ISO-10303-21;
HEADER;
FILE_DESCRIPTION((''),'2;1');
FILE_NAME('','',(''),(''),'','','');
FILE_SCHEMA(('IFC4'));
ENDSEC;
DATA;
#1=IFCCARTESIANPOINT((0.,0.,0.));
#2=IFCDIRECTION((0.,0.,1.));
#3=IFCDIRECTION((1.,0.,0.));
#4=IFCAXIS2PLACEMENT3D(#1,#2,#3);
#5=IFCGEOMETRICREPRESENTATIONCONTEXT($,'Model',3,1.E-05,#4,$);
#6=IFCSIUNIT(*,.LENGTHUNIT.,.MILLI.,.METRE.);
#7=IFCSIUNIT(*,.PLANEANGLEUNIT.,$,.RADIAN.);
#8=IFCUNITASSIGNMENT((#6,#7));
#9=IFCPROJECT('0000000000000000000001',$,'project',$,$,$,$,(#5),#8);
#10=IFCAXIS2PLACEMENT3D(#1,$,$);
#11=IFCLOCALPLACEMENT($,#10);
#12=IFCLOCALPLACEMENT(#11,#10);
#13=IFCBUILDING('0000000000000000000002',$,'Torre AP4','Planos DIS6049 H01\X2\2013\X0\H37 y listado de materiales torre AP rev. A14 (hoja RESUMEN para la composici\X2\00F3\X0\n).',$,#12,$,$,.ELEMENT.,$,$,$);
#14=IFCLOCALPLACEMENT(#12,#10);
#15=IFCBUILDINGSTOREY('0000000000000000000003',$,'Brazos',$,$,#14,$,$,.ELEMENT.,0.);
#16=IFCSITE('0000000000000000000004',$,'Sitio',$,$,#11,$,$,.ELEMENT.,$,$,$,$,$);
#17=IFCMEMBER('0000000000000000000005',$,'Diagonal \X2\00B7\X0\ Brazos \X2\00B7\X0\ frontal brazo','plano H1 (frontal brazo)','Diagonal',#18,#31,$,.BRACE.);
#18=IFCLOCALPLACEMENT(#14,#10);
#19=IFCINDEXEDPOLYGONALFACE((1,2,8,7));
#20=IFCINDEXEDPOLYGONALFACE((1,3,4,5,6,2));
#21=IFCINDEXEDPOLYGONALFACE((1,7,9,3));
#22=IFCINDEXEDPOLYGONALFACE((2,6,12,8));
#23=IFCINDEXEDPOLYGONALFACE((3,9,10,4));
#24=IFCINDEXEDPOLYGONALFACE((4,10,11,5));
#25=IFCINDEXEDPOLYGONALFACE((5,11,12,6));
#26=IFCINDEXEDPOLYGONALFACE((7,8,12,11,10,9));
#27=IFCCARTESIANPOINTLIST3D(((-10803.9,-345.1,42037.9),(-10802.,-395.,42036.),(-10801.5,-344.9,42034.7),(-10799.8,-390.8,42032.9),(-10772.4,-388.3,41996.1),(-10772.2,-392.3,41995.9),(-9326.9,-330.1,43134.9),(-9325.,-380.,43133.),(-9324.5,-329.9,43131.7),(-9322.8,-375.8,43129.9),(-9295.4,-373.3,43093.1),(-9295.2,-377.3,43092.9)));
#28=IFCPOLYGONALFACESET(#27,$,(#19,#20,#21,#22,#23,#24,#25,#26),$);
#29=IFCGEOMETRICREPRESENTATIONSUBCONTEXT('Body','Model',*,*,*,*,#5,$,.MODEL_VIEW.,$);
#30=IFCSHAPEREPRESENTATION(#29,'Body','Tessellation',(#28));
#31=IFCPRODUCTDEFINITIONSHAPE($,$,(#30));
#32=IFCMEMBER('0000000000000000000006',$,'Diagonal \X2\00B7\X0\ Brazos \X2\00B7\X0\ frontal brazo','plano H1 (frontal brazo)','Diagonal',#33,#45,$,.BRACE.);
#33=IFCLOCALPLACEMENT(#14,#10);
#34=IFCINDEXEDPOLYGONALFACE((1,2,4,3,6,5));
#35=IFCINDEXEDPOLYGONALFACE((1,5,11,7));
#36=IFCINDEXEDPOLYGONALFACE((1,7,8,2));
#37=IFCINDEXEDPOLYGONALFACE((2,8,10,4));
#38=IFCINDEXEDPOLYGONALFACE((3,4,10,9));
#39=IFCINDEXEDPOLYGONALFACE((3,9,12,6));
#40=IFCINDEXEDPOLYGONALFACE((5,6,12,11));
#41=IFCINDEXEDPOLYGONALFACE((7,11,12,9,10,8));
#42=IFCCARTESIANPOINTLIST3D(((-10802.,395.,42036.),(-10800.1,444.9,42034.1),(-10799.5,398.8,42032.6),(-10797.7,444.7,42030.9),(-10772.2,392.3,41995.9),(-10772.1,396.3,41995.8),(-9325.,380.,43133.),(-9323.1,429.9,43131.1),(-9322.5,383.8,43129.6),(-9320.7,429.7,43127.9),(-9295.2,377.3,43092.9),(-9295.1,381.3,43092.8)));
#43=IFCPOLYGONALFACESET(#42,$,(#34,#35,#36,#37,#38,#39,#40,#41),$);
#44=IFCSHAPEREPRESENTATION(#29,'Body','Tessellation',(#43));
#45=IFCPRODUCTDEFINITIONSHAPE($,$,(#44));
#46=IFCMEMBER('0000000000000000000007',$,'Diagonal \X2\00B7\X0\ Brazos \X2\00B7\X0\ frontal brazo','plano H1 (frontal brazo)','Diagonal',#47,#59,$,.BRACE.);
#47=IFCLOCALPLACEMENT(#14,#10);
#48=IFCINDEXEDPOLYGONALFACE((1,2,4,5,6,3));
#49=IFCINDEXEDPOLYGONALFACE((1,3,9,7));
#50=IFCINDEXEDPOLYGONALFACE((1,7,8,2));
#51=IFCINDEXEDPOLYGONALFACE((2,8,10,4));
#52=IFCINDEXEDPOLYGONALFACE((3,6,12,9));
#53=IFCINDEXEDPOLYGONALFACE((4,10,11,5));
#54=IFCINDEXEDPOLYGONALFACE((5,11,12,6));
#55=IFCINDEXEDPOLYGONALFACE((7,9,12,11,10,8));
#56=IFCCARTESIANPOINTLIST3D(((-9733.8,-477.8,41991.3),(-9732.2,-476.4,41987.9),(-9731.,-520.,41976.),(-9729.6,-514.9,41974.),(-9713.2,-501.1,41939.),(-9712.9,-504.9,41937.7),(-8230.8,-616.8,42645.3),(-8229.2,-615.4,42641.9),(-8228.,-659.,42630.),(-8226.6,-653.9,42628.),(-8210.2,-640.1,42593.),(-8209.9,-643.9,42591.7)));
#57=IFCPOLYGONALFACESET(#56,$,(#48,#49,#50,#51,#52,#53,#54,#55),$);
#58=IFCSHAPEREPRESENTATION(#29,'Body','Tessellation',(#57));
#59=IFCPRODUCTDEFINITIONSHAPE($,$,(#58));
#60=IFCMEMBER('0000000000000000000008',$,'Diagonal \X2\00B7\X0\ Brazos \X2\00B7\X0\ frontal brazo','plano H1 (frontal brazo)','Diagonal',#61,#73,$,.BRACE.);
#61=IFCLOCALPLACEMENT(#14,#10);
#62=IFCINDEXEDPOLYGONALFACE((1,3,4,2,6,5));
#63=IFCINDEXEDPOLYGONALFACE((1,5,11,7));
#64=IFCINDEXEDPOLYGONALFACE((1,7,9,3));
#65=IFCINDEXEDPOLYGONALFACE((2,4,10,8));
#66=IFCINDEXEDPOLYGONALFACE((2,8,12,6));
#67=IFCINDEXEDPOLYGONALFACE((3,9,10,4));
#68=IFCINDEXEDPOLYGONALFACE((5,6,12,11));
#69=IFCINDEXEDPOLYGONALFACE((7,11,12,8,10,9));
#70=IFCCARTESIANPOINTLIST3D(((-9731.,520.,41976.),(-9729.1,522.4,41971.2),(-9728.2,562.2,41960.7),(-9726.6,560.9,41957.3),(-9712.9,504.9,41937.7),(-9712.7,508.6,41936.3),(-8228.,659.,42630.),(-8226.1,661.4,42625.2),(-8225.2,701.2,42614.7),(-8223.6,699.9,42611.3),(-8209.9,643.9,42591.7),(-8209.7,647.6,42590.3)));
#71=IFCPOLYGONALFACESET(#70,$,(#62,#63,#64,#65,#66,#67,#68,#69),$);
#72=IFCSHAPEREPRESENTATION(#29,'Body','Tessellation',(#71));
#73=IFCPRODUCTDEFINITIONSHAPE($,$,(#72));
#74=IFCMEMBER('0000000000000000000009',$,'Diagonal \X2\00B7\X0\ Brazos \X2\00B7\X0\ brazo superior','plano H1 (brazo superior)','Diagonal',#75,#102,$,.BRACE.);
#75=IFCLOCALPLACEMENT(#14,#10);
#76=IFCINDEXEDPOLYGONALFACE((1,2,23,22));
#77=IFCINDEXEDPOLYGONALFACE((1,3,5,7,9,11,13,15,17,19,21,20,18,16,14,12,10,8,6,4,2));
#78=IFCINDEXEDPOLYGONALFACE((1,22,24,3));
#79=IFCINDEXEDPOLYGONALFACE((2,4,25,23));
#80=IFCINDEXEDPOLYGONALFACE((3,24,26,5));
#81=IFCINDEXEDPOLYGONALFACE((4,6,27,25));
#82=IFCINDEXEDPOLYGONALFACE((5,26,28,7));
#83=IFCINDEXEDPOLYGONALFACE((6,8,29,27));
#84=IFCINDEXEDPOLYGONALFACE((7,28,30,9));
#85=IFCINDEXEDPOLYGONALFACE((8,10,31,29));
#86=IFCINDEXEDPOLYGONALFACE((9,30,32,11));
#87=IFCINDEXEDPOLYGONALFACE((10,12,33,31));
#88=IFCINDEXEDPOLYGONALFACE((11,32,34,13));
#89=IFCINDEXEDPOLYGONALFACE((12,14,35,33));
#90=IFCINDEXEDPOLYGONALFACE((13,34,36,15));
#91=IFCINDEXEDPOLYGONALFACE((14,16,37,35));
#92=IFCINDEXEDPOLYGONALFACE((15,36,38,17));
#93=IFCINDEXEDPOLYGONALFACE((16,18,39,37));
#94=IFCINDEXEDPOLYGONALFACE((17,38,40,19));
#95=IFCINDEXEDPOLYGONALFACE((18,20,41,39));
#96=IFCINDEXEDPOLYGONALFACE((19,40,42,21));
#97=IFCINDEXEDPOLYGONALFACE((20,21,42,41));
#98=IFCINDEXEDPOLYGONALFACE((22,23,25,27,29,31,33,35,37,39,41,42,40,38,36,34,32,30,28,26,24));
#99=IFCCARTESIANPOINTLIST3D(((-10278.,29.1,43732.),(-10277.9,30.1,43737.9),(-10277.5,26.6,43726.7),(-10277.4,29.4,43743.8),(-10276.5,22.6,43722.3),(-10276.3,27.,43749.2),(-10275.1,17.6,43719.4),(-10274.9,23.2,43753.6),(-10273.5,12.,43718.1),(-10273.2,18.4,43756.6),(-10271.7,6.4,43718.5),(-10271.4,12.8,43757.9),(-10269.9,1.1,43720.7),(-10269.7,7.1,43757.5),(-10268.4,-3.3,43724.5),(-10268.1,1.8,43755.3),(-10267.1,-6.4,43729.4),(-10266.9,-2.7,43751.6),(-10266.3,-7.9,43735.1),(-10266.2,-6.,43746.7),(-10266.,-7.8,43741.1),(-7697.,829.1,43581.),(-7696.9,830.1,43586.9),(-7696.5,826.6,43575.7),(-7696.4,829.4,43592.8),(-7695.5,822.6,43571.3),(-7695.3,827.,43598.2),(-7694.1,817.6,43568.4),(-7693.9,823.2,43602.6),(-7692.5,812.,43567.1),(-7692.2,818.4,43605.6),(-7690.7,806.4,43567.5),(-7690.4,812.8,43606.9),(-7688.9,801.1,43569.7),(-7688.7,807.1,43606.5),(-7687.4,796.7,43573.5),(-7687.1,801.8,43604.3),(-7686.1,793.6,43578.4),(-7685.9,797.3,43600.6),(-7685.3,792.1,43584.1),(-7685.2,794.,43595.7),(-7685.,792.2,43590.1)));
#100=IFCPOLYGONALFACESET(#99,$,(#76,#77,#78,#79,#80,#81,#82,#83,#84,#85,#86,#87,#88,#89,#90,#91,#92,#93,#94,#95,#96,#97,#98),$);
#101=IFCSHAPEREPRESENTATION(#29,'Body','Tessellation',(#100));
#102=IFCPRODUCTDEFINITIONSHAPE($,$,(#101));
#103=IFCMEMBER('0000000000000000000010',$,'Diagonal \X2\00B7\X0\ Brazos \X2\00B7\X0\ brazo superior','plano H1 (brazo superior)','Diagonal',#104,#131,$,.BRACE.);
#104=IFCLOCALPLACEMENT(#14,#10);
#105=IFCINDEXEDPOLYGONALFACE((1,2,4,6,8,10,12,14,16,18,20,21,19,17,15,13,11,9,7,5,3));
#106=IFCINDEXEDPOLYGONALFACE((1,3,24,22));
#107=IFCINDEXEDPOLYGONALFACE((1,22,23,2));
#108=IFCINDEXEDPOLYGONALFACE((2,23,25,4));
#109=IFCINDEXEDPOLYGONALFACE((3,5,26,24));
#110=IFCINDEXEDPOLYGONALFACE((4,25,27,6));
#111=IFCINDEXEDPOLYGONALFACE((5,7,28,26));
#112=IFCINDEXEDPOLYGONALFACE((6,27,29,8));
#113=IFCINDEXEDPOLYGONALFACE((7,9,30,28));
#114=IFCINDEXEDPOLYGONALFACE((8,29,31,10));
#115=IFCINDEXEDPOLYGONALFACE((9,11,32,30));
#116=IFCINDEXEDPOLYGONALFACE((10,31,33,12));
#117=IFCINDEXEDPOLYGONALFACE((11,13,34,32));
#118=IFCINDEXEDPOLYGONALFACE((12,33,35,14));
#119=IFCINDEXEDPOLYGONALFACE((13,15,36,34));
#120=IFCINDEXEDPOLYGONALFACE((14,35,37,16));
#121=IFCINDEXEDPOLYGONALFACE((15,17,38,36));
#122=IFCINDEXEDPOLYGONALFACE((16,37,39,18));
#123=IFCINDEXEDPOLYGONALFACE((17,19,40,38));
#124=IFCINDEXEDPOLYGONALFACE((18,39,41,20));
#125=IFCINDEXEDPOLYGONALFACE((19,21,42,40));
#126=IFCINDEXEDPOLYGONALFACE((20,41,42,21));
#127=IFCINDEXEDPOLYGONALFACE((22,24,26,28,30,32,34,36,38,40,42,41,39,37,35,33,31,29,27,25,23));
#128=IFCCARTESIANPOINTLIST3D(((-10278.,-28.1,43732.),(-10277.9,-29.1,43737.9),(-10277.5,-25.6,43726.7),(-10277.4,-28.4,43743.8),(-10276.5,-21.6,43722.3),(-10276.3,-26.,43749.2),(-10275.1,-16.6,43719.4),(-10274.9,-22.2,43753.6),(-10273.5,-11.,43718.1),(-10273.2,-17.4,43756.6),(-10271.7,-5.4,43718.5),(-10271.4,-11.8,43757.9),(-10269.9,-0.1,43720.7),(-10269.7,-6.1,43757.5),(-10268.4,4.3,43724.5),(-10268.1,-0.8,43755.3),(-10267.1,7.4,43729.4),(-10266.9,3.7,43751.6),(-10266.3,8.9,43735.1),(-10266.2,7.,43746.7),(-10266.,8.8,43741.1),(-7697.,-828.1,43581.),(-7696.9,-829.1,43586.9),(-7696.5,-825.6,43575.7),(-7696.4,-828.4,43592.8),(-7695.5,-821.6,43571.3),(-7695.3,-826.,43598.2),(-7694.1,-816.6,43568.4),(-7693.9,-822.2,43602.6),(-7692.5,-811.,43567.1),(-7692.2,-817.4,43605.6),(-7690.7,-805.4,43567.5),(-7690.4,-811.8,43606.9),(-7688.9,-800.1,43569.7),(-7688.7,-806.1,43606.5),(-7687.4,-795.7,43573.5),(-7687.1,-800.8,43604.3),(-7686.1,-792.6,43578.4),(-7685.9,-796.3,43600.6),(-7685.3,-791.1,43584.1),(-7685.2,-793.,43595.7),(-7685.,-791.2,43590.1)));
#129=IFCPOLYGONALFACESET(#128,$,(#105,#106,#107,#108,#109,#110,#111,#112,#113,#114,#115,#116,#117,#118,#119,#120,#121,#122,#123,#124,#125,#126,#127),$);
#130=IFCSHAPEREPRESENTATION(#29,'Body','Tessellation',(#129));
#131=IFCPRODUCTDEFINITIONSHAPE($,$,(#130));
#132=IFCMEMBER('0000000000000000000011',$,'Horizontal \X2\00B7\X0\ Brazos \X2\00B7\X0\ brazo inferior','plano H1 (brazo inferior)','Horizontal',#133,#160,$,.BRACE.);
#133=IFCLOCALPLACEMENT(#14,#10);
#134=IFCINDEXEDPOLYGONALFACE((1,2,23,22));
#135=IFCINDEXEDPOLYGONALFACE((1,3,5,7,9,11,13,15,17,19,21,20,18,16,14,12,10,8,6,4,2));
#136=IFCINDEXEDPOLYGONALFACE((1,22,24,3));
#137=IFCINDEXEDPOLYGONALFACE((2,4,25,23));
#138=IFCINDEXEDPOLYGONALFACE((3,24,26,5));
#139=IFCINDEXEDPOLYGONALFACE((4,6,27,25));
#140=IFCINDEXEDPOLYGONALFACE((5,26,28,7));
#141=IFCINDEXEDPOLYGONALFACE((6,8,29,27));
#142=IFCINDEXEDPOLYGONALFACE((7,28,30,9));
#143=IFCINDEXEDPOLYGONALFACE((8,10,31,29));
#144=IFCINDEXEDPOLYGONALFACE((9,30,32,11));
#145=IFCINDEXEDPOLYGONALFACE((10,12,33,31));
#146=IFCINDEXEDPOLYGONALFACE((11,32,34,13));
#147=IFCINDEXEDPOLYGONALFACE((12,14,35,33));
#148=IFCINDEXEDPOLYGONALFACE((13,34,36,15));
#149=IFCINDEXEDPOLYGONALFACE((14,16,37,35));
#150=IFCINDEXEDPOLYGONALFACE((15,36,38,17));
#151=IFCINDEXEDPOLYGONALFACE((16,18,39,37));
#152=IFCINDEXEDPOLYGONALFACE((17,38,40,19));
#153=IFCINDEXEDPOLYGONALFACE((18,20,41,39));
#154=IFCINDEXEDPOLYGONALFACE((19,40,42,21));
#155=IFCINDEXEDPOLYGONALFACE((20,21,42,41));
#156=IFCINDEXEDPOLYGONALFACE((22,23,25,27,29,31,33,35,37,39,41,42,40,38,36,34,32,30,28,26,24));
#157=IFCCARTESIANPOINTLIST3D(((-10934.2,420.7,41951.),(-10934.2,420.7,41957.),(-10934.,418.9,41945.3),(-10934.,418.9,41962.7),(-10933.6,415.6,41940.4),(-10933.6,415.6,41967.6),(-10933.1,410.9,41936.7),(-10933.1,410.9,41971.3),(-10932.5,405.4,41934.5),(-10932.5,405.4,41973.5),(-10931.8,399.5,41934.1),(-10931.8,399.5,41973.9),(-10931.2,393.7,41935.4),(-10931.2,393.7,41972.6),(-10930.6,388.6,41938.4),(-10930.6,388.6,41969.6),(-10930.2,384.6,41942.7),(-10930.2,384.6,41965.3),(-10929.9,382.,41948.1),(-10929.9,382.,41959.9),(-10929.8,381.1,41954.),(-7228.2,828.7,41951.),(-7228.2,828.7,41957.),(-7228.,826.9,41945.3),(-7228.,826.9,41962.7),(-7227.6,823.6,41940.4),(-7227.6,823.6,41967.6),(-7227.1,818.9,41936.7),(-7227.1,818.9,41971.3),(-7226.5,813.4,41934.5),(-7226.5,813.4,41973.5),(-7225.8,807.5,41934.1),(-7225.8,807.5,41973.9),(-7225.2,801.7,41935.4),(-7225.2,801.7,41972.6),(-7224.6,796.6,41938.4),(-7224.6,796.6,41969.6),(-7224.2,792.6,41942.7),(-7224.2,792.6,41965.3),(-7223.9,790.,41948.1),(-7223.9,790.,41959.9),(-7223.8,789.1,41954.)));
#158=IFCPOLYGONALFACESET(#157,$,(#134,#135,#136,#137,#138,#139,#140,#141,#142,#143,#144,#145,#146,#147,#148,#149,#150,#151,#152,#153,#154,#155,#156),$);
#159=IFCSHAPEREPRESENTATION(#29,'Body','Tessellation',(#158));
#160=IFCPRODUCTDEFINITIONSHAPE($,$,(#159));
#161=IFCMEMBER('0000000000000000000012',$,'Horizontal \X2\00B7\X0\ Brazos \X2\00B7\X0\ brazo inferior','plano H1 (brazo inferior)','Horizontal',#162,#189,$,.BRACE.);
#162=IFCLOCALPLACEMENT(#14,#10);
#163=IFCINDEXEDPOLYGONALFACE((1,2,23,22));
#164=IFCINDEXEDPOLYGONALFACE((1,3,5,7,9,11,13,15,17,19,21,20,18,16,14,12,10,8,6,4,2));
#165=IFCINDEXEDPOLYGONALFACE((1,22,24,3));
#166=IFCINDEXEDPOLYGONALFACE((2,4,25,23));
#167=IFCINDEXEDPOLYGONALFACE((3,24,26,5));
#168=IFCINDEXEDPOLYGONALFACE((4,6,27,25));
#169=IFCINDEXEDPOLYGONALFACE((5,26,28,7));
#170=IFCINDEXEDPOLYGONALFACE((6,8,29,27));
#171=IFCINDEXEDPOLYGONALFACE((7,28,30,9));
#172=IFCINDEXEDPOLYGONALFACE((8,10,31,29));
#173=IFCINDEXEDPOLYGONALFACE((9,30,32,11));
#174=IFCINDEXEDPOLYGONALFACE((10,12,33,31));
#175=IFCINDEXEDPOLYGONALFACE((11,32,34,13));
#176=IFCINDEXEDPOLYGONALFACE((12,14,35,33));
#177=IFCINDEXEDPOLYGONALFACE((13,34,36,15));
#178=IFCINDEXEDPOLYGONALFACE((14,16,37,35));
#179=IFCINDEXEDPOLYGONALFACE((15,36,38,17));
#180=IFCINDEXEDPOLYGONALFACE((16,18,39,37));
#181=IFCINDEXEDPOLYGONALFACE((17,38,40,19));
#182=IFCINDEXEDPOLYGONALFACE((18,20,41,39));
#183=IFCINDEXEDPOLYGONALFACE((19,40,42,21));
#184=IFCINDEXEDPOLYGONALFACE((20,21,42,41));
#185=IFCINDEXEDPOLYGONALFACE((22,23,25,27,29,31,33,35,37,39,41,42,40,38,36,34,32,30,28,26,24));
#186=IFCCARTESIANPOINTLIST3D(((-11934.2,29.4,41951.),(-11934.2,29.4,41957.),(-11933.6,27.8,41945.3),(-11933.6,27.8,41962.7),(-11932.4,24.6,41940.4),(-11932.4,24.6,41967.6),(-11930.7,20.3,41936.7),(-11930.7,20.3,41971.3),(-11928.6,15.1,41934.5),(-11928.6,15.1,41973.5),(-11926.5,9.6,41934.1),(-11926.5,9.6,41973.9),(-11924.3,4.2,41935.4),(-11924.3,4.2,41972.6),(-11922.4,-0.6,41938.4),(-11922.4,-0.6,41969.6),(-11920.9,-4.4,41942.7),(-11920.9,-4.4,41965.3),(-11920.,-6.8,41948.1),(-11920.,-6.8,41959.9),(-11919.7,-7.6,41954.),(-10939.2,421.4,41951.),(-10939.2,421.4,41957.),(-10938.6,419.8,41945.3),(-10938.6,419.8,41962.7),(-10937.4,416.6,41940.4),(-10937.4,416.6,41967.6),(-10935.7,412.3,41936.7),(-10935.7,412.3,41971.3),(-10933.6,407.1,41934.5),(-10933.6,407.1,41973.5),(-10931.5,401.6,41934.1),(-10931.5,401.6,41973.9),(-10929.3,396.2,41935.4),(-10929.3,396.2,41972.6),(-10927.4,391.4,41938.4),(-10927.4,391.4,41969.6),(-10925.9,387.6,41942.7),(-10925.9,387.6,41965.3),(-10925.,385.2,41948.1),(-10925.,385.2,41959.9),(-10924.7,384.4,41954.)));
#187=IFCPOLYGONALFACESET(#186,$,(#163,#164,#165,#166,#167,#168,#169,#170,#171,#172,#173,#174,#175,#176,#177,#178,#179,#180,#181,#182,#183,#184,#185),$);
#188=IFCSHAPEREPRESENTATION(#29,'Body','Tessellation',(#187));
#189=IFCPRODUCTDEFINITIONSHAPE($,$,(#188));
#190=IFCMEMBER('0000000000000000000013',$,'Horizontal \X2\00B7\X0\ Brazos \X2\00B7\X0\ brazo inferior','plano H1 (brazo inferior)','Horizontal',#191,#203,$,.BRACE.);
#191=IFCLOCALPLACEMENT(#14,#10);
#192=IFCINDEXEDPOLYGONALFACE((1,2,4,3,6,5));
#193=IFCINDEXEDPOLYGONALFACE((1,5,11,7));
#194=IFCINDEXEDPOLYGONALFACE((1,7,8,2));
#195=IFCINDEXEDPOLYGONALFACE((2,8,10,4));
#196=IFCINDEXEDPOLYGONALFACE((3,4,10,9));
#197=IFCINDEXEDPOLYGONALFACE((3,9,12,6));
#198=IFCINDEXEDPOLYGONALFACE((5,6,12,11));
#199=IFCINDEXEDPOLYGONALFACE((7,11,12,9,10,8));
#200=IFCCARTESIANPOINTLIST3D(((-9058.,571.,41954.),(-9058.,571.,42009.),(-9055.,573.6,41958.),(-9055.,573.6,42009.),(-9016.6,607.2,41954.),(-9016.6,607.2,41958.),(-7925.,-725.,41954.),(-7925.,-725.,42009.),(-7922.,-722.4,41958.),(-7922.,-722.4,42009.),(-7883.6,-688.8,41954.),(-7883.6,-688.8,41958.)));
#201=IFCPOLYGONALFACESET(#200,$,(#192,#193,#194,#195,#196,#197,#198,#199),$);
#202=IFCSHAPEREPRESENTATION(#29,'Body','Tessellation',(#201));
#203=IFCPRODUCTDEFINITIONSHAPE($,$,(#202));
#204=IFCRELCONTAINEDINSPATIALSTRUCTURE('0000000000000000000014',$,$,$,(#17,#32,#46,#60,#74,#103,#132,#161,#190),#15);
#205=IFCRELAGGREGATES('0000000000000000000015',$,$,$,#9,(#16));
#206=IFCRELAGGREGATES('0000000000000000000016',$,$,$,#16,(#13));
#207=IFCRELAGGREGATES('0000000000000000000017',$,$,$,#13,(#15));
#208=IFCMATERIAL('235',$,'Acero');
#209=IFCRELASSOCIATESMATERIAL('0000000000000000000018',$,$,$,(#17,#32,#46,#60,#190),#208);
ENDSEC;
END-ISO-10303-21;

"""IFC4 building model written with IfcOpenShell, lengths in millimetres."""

from ifc_helpers import new_model, si_unit, frame, frame_2d, origin, origin_with_axes, place, context, subcontext, project, spatial, circle, l_section, extrude, material, element, save


model = new_model("IFC4")

# Units and contexts
model_context = context("Model", 3, precision=1e-05, world=origin_with_axes())
body_context = subcontext(model_context, "Body", "Model", "MODEL_VIEW")
ifc_project = project(units=[si_unit("LENGTHUNIT", "METRE", prefix="MILLI"), si_unit("PLANEANGLEUNIT", "RADIAN")], contexts=[model_context])

# Site, building, storey
site_placement = place(None, origin())
site = spatial("IfcSite", under=ifc_project, at=site_placement, Name="Sitio", CompositionType="ELEMENT")
building_placement = place(site_placement, origin())
building = spatial("IfcBuilding", under=site, at=building_placement, Name="Torre AP4", Description="Planos DIS6049 H01–H37 y listado de materiales torre AP rev. A14 (hoja RESUMEN para la composición).", CompositionType="ELEMENT")
storey_placement = place(building_placement, origin())
storey = spatial("IfcBuildingStorey", under=building, at=storey_placement, Name="Brazos", CompositionType="ELEMENT", Elevation=0.0)

# Members
ifc_material_1 = material(Name="235", Category="Acero")
for number, where, z_axis, x_axis, name in (
    (1, (-10802.0, -395.0, 42036.0), (0.802769, 0.008153, 0.596234), (0.595049, 0.053521, -0.801905), "Diagonal · Brazos · frontal brazo"),
    (2, (-10802.0, 395.0, 42036.0), (0.802769, -0.008153, 0.596234), (0.595049, -0.053521, -0.801905), "Diagonal · Brazos · frontal brazo"),
):
    element("IfcMember", number, at=place(storey_placement, frame(where, z_axis=z_axis, x_axis=x_axis)), inside=storey, material=ifc_material_1, Name=name, Description="plano H1 (frontal brazo)", ObjectType="Diagonal", PredefinedType="BRACE", context=body_context, shape_type="SweptSolid", body=[
        extrude(l_section(Depth=50.0, Width=50.0, Thickness=4.0, at=frame_2d((25.0, 25.0))), None, (0.0, 0.0, 1.0), 1839.9),
    ])
for number, where, z_axis, x_axis, name in (
    (3, (-9731.0, -520.0, 41976.0), (0.913674, -0.084498, 0.397567), (0.401755, 0.335963, -0.851893), "Diagonal · Brazos · frontal brazo"),
    (4, (-9731.0, 520.0, 41976.0), (0.913674, 0.084498, 0.397567), (0.401755, -0.335963, -0.851893), "Diagonal · Brazos · frontal brazo"),
):
    element("IfcMember", number, at=place(storey_placement, frame(where, z_axis=z_axis, x_axis=x_axis)), inside=storey, material=ifc_material_1, Name=name, Description="plano H1 (frontal brazo)", ObjectType="Diagonal", PredefinedType="BRACE", context=body_context, shape_type="SweptSolid", body=[
        extrude(l_section(Depth=45.0, Width=45.0, Thickness=4.0, at=frame_2d((22.5, 22.5))), None, (0.0, 0.0, 1.0), 1645.0),
    ])
for number, where, z_axis, x_axis, name in (
    (5, (-7691.0, 811.0, 43587.0), (-0.953681, -0.2956, 0.055795), (0.300728, -0.941427, 0.152572), "Diagonal · Brazos · brazo superior"),
    (6, (-10272.0, -10.0, 43738.0), (0.953681, -0.2956, -0.055795), (0.300729, 0.941418, 0.152624), "Diagonal · Brazos · brazo superior"),
):
    element("IfcMember", number, at=place(storey_placement, frame(where, z_axis=z_axis, x_axis=x_axis)), inside=storey, Name=name, Description="plano H1 (brazo superior)", ObjectType="Diagonal", PredefinedType="BRACE", context=body_context, shape_type="SweptSolid", body=[
        extrude(circle(Radius=20.0), None, (0.0, 0.0, 1.0), 2706.4),
    ])
member_1_placement = place(storey_placement, frame((-7226.0, 809.0, 41954.0), z_axis=(-0.993994, -0.109431, 0.0), x_axis=(0.109431, -0.993994, 0.0)))
element("IfcMember", 7, at=member_1_placement, inside=storey, Name="Horizontal · Brazos · brazo inferior", Description="plano H1 (brazo inferior)", ObjectType="Horizontal", PredefinedType="BRACE", context=body_context, shape_type="SweptSolid", body=[
    extrude(circle(Radius=20.0), None, (0.0, 0.0, 1.0), 3728.4),
])
member_2_placement = place(storey_placement, frame((-10932.0, 403.0, 41954.0), z_axis=(-0.930399, -0.366549, 0.0), x_axis=(0.366549, -0.930399, 0.0)))
element("IfcMember", 8, at=member_2_placement, inside=storey, Name="Horizontal · Brazos · brazo inferior", Description="plano H1 (brazo inferior)", ObjectType="Horizontal", PredefinedType="BRACE", context=body_context, shape_type="SweptSolid", body=[
    extrude(circle(Radius=20.0), None, (0.0, 0.0, 1.0), 1069.4),
])
member_3_placement = place(storey_placement, frame((-9058.0, 571.0, 41954.0), z_axis=(0.658176, -0.752865, 0.0), x_axis=(0.752865, 0.658176, 0.0)))
element("IfcMember", 9, at=member_3_placement, inside=storey, material=ifc_material_1, Name="Horizontal · Brazos · brazo inferior", Description="plano H1 (brazo inferior)", ObjectType="Horizontal", PredefinedType="BRACE", context=body_context, shape_type="SweptSolid", body=[
    extrude(l_section(Depth=55.0, Width=55.0, Thickness=4.0, at=frame_2d((27.5, 27.5))), None, (0.0, 0.0, 1.0), 1721.4),
])

save(model, "model.ifc")
